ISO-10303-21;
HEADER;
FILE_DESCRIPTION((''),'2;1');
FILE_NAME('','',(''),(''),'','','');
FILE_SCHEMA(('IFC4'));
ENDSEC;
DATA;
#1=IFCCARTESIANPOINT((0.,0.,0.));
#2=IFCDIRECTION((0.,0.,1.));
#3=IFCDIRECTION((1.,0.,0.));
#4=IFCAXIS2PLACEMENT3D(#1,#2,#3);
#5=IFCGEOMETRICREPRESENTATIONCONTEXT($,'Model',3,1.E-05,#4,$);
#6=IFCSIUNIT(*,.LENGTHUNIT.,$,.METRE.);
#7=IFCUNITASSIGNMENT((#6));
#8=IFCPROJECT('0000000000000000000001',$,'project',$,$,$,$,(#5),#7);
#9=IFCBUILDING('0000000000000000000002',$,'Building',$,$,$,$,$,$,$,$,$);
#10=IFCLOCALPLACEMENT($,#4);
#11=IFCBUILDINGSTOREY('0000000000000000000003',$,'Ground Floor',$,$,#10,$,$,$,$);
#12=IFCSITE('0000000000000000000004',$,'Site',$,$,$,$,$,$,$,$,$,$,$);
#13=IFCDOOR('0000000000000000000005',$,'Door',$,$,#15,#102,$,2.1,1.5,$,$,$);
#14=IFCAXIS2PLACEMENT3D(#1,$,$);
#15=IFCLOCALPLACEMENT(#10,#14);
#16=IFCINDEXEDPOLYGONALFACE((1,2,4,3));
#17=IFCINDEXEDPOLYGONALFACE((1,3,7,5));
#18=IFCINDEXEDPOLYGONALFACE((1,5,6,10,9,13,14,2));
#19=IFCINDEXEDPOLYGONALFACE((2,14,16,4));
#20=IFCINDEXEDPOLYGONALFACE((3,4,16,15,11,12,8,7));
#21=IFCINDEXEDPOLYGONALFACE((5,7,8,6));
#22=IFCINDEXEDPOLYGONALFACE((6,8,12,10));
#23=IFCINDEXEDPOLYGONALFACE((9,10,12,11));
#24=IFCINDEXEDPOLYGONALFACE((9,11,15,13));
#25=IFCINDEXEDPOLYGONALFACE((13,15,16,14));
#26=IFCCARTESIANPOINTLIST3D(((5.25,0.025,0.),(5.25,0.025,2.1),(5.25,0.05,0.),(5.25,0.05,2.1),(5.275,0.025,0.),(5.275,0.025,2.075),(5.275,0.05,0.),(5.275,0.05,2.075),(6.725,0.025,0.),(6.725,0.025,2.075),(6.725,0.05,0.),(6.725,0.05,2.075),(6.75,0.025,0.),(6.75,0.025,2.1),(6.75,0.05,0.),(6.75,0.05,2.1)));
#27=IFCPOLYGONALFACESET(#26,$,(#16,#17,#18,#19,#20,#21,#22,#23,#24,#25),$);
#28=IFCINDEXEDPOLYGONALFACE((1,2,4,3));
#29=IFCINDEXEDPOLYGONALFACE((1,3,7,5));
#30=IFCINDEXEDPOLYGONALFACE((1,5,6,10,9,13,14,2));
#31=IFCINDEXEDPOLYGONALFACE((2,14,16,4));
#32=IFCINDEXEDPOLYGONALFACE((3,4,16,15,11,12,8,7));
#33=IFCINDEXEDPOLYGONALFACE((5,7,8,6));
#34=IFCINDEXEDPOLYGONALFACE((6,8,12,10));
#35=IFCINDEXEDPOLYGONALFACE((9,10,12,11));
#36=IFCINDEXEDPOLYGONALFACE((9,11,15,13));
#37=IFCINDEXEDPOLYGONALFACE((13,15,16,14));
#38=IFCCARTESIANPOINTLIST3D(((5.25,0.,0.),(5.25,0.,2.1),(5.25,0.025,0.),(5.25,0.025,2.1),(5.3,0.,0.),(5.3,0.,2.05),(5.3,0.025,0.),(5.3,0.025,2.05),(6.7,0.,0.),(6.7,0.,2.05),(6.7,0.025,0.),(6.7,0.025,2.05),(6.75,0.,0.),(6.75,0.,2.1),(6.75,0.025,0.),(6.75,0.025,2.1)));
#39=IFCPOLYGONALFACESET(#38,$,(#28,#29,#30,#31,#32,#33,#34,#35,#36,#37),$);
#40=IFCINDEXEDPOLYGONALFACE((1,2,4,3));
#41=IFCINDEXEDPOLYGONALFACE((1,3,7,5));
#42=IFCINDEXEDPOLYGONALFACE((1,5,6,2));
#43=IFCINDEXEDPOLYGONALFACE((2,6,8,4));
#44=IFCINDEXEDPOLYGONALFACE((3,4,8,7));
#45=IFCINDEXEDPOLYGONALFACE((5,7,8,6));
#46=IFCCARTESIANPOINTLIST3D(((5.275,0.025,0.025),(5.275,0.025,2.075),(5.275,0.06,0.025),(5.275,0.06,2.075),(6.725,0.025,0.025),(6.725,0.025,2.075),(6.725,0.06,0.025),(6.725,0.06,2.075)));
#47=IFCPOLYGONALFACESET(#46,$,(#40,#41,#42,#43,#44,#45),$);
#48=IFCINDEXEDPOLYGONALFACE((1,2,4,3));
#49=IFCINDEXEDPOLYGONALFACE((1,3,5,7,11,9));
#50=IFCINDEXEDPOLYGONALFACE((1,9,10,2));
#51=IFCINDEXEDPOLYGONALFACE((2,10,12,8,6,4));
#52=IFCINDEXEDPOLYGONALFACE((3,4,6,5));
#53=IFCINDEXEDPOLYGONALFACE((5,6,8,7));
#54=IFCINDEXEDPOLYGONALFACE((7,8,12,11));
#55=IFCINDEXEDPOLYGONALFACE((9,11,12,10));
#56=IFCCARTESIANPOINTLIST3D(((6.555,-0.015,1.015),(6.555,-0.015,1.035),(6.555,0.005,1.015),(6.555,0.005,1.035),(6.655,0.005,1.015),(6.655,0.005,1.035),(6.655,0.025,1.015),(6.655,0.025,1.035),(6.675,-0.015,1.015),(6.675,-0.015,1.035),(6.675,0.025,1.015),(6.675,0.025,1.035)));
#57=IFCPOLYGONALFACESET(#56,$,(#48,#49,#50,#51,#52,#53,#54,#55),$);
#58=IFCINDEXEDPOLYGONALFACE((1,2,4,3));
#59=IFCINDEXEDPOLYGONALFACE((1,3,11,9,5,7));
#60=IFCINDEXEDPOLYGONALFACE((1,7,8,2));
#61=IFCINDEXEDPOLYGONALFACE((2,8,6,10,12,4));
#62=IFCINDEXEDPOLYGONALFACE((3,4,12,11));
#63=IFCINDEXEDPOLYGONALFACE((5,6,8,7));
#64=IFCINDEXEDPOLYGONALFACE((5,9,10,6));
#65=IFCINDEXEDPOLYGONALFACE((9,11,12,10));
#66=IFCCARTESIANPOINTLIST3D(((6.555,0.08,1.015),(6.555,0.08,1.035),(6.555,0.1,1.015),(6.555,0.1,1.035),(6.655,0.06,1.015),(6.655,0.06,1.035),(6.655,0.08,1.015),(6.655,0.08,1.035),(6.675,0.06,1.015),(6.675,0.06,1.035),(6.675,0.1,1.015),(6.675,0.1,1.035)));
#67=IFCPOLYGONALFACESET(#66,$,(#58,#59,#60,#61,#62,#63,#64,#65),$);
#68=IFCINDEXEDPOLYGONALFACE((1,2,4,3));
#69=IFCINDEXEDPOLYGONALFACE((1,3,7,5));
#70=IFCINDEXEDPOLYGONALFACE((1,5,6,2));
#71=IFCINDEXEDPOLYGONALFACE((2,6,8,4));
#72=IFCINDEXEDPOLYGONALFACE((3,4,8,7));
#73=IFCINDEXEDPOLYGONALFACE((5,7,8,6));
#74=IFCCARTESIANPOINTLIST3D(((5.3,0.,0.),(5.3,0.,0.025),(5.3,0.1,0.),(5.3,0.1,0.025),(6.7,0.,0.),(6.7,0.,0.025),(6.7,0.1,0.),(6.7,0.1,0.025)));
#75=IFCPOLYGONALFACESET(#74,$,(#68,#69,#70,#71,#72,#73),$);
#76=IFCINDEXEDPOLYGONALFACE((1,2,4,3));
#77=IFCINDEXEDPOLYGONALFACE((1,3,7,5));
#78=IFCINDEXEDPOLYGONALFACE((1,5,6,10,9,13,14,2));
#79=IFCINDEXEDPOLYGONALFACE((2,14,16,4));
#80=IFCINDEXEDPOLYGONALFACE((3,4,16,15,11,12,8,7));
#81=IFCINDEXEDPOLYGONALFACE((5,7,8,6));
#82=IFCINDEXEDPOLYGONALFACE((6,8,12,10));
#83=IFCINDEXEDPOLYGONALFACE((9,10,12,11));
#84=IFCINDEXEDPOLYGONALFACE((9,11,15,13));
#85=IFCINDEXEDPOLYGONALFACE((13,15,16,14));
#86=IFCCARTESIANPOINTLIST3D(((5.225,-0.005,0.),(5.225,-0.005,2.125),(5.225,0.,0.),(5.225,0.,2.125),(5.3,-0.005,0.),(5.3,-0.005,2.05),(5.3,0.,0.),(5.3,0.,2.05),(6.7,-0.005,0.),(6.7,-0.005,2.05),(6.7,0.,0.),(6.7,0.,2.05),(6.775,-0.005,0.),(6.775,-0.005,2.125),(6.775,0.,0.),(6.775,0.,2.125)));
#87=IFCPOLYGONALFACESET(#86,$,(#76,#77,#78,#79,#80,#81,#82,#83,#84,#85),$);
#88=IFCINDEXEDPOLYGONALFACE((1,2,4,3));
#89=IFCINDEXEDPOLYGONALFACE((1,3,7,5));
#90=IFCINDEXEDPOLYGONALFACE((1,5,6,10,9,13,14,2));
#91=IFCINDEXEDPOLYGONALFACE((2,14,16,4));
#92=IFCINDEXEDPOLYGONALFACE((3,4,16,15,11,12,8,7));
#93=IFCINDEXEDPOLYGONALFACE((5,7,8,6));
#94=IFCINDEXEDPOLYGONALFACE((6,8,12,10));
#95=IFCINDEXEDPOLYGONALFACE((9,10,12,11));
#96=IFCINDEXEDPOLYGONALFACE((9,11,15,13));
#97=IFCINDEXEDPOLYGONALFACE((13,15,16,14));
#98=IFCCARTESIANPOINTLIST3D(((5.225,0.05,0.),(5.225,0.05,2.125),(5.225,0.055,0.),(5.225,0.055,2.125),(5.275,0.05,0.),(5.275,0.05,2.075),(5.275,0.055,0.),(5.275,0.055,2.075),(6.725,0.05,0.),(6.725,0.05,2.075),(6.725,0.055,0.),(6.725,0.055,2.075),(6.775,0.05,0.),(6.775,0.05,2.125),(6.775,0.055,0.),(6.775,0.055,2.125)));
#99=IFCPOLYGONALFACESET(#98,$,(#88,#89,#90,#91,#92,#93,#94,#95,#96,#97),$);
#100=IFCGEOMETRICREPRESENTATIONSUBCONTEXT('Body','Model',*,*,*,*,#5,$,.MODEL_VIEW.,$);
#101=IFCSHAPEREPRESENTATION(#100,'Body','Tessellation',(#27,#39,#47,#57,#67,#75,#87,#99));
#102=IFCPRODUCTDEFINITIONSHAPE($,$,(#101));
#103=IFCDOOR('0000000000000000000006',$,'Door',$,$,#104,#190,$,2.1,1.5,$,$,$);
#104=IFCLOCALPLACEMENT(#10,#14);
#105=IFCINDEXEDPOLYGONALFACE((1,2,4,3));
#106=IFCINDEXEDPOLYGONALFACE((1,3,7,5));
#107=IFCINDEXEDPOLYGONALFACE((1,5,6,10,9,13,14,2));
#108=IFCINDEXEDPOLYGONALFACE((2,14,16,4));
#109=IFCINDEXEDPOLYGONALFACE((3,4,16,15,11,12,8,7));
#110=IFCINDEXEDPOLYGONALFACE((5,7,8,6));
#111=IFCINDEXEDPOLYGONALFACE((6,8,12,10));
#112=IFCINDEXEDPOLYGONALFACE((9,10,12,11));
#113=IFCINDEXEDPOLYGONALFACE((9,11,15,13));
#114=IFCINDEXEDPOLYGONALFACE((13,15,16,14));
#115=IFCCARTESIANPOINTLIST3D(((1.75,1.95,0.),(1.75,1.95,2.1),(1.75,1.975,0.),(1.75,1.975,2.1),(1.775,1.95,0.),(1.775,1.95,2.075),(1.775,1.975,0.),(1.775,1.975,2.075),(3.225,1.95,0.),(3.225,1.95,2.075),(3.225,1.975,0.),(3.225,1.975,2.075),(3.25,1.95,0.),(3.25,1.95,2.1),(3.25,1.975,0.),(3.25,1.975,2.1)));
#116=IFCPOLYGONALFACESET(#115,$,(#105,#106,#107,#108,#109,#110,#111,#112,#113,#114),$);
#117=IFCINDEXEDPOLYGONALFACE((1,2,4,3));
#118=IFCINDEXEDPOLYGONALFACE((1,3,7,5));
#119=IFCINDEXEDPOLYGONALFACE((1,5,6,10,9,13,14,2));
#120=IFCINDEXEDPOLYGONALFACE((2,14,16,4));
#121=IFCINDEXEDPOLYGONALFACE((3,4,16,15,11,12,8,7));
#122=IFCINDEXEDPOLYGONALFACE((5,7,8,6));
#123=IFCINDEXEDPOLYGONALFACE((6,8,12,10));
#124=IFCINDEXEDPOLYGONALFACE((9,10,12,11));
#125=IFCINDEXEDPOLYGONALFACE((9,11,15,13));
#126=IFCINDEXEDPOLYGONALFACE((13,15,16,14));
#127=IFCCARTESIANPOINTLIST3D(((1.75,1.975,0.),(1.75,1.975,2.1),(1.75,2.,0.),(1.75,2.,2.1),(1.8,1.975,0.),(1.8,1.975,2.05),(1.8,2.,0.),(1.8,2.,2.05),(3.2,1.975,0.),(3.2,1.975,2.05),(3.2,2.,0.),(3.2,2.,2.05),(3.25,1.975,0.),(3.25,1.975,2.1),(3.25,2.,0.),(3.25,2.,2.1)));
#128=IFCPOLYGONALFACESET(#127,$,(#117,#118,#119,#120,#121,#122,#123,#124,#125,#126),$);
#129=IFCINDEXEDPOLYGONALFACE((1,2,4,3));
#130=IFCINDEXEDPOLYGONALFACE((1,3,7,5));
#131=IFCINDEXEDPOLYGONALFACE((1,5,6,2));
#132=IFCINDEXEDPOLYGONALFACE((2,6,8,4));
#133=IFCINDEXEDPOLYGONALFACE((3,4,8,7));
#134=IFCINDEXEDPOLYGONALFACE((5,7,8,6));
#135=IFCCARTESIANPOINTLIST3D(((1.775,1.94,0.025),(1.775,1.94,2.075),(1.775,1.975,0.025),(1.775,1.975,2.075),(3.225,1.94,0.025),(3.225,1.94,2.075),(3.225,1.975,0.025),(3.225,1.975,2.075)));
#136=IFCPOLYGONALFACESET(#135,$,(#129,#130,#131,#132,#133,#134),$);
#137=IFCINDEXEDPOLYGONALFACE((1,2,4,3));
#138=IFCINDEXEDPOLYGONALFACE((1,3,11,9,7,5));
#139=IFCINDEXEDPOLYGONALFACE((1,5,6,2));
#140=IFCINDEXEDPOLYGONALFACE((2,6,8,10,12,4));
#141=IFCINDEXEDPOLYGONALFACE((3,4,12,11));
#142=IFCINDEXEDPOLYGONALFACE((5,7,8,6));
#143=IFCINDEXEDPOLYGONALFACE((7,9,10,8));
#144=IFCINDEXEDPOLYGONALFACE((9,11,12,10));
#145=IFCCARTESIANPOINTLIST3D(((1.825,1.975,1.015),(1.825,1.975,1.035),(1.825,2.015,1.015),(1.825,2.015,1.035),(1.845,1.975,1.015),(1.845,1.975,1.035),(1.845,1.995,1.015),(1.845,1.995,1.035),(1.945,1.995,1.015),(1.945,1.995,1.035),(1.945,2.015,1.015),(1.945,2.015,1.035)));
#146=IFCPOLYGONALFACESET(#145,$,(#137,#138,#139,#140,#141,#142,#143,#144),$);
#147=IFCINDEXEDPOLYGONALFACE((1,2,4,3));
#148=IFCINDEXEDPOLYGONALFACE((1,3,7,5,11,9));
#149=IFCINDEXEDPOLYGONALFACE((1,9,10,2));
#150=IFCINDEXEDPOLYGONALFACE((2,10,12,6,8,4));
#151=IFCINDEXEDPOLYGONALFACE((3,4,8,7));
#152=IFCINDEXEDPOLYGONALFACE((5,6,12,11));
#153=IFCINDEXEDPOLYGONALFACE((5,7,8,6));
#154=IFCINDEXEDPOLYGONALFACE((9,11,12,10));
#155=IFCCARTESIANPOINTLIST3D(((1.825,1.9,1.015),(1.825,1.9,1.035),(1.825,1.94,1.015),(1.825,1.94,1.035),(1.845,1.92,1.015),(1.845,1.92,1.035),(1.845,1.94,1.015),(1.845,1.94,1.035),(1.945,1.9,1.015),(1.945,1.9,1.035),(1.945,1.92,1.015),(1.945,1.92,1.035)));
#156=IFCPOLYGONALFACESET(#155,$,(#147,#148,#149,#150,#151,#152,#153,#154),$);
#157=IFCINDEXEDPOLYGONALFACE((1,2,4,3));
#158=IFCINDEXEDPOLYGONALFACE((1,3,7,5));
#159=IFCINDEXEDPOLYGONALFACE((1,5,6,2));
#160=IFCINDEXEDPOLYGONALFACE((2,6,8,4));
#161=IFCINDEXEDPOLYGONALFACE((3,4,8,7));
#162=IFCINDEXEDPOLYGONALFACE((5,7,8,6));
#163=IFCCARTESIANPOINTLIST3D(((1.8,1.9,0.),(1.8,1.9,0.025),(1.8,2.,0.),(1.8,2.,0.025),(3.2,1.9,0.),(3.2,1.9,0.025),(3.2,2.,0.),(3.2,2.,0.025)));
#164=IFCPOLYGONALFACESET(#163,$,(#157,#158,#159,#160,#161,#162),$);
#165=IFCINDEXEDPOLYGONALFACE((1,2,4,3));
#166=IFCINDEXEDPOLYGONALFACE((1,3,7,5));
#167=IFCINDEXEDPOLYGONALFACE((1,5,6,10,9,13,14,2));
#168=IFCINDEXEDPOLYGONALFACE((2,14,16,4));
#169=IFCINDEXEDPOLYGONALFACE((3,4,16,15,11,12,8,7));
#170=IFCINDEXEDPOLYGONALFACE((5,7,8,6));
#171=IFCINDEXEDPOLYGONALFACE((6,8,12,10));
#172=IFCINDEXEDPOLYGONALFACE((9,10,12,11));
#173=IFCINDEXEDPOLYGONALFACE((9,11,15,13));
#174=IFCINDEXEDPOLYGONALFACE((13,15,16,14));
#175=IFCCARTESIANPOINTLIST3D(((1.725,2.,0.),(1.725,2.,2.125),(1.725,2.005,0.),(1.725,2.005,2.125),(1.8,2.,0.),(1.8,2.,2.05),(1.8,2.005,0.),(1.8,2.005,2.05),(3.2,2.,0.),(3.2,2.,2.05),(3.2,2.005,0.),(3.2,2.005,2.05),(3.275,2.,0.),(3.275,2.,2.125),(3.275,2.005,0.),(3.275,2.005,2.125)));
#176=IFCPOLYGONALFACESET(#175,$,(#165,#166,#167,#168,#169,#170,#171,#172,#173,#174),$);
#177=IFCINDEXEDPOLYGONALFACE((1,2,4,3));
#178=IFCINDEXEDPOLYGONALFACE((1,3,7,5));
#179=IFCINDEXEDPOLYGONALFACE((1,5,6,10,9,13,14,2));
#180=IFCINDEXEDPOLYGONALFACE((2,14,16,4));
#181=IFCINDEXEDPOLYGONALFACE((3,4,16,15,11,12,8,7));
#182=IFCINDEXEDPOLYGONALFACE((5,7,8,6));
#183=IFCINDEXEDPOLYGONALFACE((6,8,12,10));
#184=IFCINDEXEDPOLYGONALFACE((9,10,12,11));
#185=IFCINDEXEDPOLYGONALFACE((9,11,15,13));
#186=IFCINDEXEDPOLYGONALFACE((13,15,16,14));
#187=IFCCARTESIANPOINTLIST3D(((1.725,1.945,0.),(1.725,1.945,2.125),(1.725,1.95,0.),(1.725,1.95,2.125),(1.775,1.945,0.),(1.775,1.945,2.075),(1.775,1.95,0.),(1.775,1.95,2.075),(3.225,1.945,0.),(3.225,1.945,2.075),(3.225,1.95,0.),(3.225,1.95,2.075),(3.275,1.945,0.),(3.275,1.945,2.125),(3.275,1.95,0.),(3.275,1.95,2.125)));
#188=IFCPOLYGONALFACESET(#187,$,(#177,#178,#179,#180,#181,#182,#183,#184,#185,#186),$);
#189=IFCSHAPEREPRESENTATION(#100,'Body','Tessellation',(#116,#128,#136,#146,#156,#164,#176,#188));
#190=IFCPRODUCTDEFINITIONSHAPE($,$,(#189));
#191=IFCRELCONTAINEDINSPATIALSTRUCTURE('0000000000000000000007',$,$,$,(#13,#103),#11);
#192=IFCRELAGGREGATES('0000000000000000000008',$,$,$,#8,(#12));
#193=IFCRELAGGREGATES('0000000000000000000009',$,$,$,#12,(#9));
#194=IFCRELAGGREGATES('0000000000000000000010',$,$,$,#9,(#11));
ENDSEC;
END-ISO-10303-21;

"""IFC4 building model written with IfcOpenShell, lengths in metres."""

from ifc_helpers import new_model, si_unit, frame, origin_with_axes, place, context, subcontext, project, spatial, line, indexed_curve, outline, extrude, element, save


model = new_model("IFC4")

# Units and contexts
model_context = context("Model", 3, precision=1e-05, world=origin_with_axes())
body_context = subcontext(model_context, "Body", "Model", "MODEL_VIEW")
ifc_project = project(units=[si_unit("LENGTHUNIT", "METRE")], contexts=[model_context])

# Site, building, storey
site = spatial("IfcSite", under=ifc_project, Name="Site")
building = spatial("IfcBuilding", under=site, Name="Building")
storey_placement = place(None, origin_with_axes())
storey = spatial("IfcBuildingStorey", under=building, at=storey_placement, Name="Ground Floor")

# Doors
door_1_placement = place(storey_placement, frame((5.25, 0.0, 0.0), z_axis=(0.0, 0.0, 1.0), x_axis=(1.0, 0.0, 0.0)))
element("IfcDoor", 1, at=door_1_placement, inside=storey, Name="Door", OverallHeight=2.1, OverallWidth=1.5, context=body_context, shape_type="SweptSolid", body=[
    extrude(outline(indexed_curve([(0.0, 0.0), (0.0, 2.1), (1.5, 2.1), (1.5, 0.0), (1.475, 0.0), (1.475, 2.075), (0.025, 2.075), (0.025, 0.0)], segments=[line(1, 2, 3, 4, 5, 6, 7, 8, 1)])), frame((0.0, 0.025, 0.0), z_axis=(0.0, -1.0, 0.0), x_axis=(1.0, 0.0, 0.0)), (0.0, 0.0, -1.0), 0.025),
    extrude(outline(indexed_curve([(0.0, 0.0), (0.0, 2.1), (1.5, 2.1), (1.5, 0.0), (1.45, 0.0), (1.45, 2.05), (0.05, 2.05), (0.05, 0.0)], segments=[line(1, 2, 3, 4, 5, 6, 7, 8, 1)])), frame((0.0, 0.0, 0.0), z_axis=(0.0, -1.0, 0.0), x_axis=(1.0, 0.0, 0.0)), (0.0, 0.0, -1.0), 0.025),
    extrude(outline(indexed_curve([(0.0, 0.0), (1.45, 0.0), (1.45, 0.035), (0.0, 0.035)], segments=[line(1, 2, 3, 4, 1)])), frame((0.025, 0.025, 0.025), z_axis=(0.0, 0.0, 1.0), x_axis=(1.0, 0.0, 0.0)), (0.0, 0.0, 1.0), 2.05),
    extrude(outline(indexed_curve([(0.0, 0.0), (0.0, -0.04), (-0.12, -0.04), (-0.12, -0.02), (-0.02, -0.02), (-0.02, 0.0)], segments=[line(1, 2, 3, 4, 5, 6, 1)])), frame((1.425, 0.025, 1.015), z_axis=(0.0, 0.0, 1.0), x_axis=(1.0, 0.0, 0.0)), (0.0, 0.0, 1.0), 0.02),
    extrude(outline(indexed_curve([(0.0, 0.0), (0.0, 0.04), (-0.12, 0.04), (-0.12, 0.02), (-0.02, 0.02), (-0.02, 0.0)], segments=[line(1, 2, 3, 4, 5, 6, 1)])), frame((1.425, 0.06, 1.015), z_axis=(0.0, 0.0, 1.0), x_axis=(1.0, 0.0, 0.0)), (0.0, 0.0, 1.0), 0.02),
    extrude(outline(indexed_curve([(0.0, 0.0), (1.4, 0.0), (1.4, 0.1), (0.0, 0.1)], segments=[line(1, 2, 3, 4, 1)])), frame((0.05, 0.0, 0.0), z_axis=(0.0, 0.0, 1.0), x_axis=(1.0, 0.0, 0.0)), (0.0, 0.0, 1.0), 0.025),
    extrude(outline(indexed_curve([(0.0, 0.0), (0.0, 2.125), (1.55, 2.125), (1.55, 0.0), (1.475, 0.0), (1.475, 2.05), (0.075, 2.05), (0.075, 0.0)], segments=[line(1, 2, 3, 4, 5, 6, 7, 8, 1)])), frame((-0.025, -0.005, 0.0), z_axis=(0.0, -1.0, 0.0), x_axis=(1.0, 0.0, 0.0)), (0.0, 0.0, -1.0), 0.005),
    extrude(outline(indexed_curve([(0.0, 0.0), (0.0, 2.125), (1.55, 2.125), (1.55, 0.0), (1.5, 0.0), (1.5, 2.075), (0.05, 2.075), (0.05, 0.0)], segments=[line(1, 2, 3, 4, 5, 6, 7, 8, 1)])), frame((-0.025, 0.05, 0.0), z_axis=(0.0, -1.0, 0.0), x_axis=(1.0, 0.0, 0.0)), (0.0, 0.0, -1.0), 0.005),
])
door_2_placement = place(storey_placement, frame((3.25, 2.0, 0.0), z_axis=(0.0, 0.0, 1.0), x_axis=(-1.0, 0.0, 0.0)))
element("IfcDoor", 2, at=door_2_placement, inside=storey, Name="Door", OverallHeight=2.1, OverallWidth=1.5, context=body_context, shape_type="SweptSolid", body=[
    extrude(outline(indexed_curve([(0.0, 0.0), (0.0, 2.1), (1.5, 2.1), (1.5, 0.0), (1.475, 0.0), (1.475, 2.075), (0.025, 2.075), (0.025, 0.0)], segments=[line(1, 2, 3, 4, 5, 6, 7, 8, 1)])), frame((0.0, 0.025, 0.0), z_axis=(0.0, -1.0, 0.0), x_axis=(1.0, 0.0, 0.0)), (0.0, 0.0, -1.0), 0.025),
    extrude(outline(indexed_curve([(0.0, 0.0), (0.0, 2.1), (1.5, 2.1), (1.5, 0.0), (1.45, 0.0), (1.45, 2.05), (0.05, 2.05), (0.05, 0.0)], segments=[line(1, 2, 3, 4, 5, 6, 7, 8, 1)])), frame((0.0, 0.0, 0.0), z_axis=(0.0, -1.0, 0.0), x_axis=(1.0, 0.0, 0.0)), (0.0, 0.0, -1.0), 0.025),
    extrude(outline(indexed_curve([(0.0, 0.0), (1.45, 0.0), (1.45, 0.035), (0.0, 0.035)], segments=[line(1, 2, 3, 4, 1)])), frame((0.025, 0.025, 0.025), z_axis=(0.0, 0.0, 1.0), x_axis=(1.0, 0.0, 0.0)), (0.0, 0.0, 1.0), 2.05),
    extrude(outline(indexed_curve([(0.0, 0.0), (0.0, -0.04), (-0.12, -0.04), (-0.12, -0.02), (-0.02, -0.02), (-0.02, 0.0)], segments=[line(1, 2, 3, 4, 5, 6, 1)])), frame((1.425, 0.025, 1.015), z_axis=(0.0, 0.0, 1.0), x_axis=(1.0, 0.0, 0.0)), (0.0, 0.0, 1.0), 0.02),
    extrude(outline(indexed_curve([(0.0, 0.0), (0.0, 0.04), (-0.12, 0.04), (-0.12, 0.02), (-0.02, 0.02), (-0.02, 0.0)], segments=[line(1, 2, 3, 4, 5, 6, 1)])), frame((1.425, 0.06, 1.015), z_axis=(0.0, 0.0, 1.0), x_axis=(1.0, 0.0, 0.0)), (0.0, 0.0, 1.0), 0.02),
    extrude(outline(indexed_curve([(0.0, 0.0), (1.4, 0.0), (1.4, 0.1), (0.0, 0.1)], segments=[line(1, 2, 3, 4, 1)])), frame((0.05, 0.0, 0.0), z_axis=(0.0, 0.0, 1.0), x_axis=(1.0, 0.0, 0.0)), (0.0, 0.0, 1.0), 0.025),
    extrude(outline(indexed_curve([(0.0, 0.0), (0.0, 2.125), (1.55, 2.125), (1.55, 0.0), (1.475, 0.0), (1.475, 2.05), (0.075, 2.05), (0.075, 0.0)], segments=[line(1, 2, 3, 4, 5, 6, 7, 8, 1)])), frame((-0.025, -0.005, 0.0), z_axis=(0.0, -1.0, 0.0), x_axis=(1.0, 0.0, 0.0)), (0.0, 0.0, -1.0), 0.005),
    extrude(outline(indexed_curve([(0.0, 0.0), (0.0, 2.125), (1.55, 2.125), (1.55, 0.0), (1.5, 0.0), (1.5, 2.075), (0.05, 2.075), (0.05, 0.0)], segments=[line(1, 2, 3, 4, 5, 6, 7, 8, 1)])), frame((-0.025, 0.05, 0.0), z_axis=(0.0, -1.0, 0.0), x_axis=(1.0, 0.0, 0.0)), (0.0, 0.0, -1.0), 0.005),
])

save(model, "model.ifc")
